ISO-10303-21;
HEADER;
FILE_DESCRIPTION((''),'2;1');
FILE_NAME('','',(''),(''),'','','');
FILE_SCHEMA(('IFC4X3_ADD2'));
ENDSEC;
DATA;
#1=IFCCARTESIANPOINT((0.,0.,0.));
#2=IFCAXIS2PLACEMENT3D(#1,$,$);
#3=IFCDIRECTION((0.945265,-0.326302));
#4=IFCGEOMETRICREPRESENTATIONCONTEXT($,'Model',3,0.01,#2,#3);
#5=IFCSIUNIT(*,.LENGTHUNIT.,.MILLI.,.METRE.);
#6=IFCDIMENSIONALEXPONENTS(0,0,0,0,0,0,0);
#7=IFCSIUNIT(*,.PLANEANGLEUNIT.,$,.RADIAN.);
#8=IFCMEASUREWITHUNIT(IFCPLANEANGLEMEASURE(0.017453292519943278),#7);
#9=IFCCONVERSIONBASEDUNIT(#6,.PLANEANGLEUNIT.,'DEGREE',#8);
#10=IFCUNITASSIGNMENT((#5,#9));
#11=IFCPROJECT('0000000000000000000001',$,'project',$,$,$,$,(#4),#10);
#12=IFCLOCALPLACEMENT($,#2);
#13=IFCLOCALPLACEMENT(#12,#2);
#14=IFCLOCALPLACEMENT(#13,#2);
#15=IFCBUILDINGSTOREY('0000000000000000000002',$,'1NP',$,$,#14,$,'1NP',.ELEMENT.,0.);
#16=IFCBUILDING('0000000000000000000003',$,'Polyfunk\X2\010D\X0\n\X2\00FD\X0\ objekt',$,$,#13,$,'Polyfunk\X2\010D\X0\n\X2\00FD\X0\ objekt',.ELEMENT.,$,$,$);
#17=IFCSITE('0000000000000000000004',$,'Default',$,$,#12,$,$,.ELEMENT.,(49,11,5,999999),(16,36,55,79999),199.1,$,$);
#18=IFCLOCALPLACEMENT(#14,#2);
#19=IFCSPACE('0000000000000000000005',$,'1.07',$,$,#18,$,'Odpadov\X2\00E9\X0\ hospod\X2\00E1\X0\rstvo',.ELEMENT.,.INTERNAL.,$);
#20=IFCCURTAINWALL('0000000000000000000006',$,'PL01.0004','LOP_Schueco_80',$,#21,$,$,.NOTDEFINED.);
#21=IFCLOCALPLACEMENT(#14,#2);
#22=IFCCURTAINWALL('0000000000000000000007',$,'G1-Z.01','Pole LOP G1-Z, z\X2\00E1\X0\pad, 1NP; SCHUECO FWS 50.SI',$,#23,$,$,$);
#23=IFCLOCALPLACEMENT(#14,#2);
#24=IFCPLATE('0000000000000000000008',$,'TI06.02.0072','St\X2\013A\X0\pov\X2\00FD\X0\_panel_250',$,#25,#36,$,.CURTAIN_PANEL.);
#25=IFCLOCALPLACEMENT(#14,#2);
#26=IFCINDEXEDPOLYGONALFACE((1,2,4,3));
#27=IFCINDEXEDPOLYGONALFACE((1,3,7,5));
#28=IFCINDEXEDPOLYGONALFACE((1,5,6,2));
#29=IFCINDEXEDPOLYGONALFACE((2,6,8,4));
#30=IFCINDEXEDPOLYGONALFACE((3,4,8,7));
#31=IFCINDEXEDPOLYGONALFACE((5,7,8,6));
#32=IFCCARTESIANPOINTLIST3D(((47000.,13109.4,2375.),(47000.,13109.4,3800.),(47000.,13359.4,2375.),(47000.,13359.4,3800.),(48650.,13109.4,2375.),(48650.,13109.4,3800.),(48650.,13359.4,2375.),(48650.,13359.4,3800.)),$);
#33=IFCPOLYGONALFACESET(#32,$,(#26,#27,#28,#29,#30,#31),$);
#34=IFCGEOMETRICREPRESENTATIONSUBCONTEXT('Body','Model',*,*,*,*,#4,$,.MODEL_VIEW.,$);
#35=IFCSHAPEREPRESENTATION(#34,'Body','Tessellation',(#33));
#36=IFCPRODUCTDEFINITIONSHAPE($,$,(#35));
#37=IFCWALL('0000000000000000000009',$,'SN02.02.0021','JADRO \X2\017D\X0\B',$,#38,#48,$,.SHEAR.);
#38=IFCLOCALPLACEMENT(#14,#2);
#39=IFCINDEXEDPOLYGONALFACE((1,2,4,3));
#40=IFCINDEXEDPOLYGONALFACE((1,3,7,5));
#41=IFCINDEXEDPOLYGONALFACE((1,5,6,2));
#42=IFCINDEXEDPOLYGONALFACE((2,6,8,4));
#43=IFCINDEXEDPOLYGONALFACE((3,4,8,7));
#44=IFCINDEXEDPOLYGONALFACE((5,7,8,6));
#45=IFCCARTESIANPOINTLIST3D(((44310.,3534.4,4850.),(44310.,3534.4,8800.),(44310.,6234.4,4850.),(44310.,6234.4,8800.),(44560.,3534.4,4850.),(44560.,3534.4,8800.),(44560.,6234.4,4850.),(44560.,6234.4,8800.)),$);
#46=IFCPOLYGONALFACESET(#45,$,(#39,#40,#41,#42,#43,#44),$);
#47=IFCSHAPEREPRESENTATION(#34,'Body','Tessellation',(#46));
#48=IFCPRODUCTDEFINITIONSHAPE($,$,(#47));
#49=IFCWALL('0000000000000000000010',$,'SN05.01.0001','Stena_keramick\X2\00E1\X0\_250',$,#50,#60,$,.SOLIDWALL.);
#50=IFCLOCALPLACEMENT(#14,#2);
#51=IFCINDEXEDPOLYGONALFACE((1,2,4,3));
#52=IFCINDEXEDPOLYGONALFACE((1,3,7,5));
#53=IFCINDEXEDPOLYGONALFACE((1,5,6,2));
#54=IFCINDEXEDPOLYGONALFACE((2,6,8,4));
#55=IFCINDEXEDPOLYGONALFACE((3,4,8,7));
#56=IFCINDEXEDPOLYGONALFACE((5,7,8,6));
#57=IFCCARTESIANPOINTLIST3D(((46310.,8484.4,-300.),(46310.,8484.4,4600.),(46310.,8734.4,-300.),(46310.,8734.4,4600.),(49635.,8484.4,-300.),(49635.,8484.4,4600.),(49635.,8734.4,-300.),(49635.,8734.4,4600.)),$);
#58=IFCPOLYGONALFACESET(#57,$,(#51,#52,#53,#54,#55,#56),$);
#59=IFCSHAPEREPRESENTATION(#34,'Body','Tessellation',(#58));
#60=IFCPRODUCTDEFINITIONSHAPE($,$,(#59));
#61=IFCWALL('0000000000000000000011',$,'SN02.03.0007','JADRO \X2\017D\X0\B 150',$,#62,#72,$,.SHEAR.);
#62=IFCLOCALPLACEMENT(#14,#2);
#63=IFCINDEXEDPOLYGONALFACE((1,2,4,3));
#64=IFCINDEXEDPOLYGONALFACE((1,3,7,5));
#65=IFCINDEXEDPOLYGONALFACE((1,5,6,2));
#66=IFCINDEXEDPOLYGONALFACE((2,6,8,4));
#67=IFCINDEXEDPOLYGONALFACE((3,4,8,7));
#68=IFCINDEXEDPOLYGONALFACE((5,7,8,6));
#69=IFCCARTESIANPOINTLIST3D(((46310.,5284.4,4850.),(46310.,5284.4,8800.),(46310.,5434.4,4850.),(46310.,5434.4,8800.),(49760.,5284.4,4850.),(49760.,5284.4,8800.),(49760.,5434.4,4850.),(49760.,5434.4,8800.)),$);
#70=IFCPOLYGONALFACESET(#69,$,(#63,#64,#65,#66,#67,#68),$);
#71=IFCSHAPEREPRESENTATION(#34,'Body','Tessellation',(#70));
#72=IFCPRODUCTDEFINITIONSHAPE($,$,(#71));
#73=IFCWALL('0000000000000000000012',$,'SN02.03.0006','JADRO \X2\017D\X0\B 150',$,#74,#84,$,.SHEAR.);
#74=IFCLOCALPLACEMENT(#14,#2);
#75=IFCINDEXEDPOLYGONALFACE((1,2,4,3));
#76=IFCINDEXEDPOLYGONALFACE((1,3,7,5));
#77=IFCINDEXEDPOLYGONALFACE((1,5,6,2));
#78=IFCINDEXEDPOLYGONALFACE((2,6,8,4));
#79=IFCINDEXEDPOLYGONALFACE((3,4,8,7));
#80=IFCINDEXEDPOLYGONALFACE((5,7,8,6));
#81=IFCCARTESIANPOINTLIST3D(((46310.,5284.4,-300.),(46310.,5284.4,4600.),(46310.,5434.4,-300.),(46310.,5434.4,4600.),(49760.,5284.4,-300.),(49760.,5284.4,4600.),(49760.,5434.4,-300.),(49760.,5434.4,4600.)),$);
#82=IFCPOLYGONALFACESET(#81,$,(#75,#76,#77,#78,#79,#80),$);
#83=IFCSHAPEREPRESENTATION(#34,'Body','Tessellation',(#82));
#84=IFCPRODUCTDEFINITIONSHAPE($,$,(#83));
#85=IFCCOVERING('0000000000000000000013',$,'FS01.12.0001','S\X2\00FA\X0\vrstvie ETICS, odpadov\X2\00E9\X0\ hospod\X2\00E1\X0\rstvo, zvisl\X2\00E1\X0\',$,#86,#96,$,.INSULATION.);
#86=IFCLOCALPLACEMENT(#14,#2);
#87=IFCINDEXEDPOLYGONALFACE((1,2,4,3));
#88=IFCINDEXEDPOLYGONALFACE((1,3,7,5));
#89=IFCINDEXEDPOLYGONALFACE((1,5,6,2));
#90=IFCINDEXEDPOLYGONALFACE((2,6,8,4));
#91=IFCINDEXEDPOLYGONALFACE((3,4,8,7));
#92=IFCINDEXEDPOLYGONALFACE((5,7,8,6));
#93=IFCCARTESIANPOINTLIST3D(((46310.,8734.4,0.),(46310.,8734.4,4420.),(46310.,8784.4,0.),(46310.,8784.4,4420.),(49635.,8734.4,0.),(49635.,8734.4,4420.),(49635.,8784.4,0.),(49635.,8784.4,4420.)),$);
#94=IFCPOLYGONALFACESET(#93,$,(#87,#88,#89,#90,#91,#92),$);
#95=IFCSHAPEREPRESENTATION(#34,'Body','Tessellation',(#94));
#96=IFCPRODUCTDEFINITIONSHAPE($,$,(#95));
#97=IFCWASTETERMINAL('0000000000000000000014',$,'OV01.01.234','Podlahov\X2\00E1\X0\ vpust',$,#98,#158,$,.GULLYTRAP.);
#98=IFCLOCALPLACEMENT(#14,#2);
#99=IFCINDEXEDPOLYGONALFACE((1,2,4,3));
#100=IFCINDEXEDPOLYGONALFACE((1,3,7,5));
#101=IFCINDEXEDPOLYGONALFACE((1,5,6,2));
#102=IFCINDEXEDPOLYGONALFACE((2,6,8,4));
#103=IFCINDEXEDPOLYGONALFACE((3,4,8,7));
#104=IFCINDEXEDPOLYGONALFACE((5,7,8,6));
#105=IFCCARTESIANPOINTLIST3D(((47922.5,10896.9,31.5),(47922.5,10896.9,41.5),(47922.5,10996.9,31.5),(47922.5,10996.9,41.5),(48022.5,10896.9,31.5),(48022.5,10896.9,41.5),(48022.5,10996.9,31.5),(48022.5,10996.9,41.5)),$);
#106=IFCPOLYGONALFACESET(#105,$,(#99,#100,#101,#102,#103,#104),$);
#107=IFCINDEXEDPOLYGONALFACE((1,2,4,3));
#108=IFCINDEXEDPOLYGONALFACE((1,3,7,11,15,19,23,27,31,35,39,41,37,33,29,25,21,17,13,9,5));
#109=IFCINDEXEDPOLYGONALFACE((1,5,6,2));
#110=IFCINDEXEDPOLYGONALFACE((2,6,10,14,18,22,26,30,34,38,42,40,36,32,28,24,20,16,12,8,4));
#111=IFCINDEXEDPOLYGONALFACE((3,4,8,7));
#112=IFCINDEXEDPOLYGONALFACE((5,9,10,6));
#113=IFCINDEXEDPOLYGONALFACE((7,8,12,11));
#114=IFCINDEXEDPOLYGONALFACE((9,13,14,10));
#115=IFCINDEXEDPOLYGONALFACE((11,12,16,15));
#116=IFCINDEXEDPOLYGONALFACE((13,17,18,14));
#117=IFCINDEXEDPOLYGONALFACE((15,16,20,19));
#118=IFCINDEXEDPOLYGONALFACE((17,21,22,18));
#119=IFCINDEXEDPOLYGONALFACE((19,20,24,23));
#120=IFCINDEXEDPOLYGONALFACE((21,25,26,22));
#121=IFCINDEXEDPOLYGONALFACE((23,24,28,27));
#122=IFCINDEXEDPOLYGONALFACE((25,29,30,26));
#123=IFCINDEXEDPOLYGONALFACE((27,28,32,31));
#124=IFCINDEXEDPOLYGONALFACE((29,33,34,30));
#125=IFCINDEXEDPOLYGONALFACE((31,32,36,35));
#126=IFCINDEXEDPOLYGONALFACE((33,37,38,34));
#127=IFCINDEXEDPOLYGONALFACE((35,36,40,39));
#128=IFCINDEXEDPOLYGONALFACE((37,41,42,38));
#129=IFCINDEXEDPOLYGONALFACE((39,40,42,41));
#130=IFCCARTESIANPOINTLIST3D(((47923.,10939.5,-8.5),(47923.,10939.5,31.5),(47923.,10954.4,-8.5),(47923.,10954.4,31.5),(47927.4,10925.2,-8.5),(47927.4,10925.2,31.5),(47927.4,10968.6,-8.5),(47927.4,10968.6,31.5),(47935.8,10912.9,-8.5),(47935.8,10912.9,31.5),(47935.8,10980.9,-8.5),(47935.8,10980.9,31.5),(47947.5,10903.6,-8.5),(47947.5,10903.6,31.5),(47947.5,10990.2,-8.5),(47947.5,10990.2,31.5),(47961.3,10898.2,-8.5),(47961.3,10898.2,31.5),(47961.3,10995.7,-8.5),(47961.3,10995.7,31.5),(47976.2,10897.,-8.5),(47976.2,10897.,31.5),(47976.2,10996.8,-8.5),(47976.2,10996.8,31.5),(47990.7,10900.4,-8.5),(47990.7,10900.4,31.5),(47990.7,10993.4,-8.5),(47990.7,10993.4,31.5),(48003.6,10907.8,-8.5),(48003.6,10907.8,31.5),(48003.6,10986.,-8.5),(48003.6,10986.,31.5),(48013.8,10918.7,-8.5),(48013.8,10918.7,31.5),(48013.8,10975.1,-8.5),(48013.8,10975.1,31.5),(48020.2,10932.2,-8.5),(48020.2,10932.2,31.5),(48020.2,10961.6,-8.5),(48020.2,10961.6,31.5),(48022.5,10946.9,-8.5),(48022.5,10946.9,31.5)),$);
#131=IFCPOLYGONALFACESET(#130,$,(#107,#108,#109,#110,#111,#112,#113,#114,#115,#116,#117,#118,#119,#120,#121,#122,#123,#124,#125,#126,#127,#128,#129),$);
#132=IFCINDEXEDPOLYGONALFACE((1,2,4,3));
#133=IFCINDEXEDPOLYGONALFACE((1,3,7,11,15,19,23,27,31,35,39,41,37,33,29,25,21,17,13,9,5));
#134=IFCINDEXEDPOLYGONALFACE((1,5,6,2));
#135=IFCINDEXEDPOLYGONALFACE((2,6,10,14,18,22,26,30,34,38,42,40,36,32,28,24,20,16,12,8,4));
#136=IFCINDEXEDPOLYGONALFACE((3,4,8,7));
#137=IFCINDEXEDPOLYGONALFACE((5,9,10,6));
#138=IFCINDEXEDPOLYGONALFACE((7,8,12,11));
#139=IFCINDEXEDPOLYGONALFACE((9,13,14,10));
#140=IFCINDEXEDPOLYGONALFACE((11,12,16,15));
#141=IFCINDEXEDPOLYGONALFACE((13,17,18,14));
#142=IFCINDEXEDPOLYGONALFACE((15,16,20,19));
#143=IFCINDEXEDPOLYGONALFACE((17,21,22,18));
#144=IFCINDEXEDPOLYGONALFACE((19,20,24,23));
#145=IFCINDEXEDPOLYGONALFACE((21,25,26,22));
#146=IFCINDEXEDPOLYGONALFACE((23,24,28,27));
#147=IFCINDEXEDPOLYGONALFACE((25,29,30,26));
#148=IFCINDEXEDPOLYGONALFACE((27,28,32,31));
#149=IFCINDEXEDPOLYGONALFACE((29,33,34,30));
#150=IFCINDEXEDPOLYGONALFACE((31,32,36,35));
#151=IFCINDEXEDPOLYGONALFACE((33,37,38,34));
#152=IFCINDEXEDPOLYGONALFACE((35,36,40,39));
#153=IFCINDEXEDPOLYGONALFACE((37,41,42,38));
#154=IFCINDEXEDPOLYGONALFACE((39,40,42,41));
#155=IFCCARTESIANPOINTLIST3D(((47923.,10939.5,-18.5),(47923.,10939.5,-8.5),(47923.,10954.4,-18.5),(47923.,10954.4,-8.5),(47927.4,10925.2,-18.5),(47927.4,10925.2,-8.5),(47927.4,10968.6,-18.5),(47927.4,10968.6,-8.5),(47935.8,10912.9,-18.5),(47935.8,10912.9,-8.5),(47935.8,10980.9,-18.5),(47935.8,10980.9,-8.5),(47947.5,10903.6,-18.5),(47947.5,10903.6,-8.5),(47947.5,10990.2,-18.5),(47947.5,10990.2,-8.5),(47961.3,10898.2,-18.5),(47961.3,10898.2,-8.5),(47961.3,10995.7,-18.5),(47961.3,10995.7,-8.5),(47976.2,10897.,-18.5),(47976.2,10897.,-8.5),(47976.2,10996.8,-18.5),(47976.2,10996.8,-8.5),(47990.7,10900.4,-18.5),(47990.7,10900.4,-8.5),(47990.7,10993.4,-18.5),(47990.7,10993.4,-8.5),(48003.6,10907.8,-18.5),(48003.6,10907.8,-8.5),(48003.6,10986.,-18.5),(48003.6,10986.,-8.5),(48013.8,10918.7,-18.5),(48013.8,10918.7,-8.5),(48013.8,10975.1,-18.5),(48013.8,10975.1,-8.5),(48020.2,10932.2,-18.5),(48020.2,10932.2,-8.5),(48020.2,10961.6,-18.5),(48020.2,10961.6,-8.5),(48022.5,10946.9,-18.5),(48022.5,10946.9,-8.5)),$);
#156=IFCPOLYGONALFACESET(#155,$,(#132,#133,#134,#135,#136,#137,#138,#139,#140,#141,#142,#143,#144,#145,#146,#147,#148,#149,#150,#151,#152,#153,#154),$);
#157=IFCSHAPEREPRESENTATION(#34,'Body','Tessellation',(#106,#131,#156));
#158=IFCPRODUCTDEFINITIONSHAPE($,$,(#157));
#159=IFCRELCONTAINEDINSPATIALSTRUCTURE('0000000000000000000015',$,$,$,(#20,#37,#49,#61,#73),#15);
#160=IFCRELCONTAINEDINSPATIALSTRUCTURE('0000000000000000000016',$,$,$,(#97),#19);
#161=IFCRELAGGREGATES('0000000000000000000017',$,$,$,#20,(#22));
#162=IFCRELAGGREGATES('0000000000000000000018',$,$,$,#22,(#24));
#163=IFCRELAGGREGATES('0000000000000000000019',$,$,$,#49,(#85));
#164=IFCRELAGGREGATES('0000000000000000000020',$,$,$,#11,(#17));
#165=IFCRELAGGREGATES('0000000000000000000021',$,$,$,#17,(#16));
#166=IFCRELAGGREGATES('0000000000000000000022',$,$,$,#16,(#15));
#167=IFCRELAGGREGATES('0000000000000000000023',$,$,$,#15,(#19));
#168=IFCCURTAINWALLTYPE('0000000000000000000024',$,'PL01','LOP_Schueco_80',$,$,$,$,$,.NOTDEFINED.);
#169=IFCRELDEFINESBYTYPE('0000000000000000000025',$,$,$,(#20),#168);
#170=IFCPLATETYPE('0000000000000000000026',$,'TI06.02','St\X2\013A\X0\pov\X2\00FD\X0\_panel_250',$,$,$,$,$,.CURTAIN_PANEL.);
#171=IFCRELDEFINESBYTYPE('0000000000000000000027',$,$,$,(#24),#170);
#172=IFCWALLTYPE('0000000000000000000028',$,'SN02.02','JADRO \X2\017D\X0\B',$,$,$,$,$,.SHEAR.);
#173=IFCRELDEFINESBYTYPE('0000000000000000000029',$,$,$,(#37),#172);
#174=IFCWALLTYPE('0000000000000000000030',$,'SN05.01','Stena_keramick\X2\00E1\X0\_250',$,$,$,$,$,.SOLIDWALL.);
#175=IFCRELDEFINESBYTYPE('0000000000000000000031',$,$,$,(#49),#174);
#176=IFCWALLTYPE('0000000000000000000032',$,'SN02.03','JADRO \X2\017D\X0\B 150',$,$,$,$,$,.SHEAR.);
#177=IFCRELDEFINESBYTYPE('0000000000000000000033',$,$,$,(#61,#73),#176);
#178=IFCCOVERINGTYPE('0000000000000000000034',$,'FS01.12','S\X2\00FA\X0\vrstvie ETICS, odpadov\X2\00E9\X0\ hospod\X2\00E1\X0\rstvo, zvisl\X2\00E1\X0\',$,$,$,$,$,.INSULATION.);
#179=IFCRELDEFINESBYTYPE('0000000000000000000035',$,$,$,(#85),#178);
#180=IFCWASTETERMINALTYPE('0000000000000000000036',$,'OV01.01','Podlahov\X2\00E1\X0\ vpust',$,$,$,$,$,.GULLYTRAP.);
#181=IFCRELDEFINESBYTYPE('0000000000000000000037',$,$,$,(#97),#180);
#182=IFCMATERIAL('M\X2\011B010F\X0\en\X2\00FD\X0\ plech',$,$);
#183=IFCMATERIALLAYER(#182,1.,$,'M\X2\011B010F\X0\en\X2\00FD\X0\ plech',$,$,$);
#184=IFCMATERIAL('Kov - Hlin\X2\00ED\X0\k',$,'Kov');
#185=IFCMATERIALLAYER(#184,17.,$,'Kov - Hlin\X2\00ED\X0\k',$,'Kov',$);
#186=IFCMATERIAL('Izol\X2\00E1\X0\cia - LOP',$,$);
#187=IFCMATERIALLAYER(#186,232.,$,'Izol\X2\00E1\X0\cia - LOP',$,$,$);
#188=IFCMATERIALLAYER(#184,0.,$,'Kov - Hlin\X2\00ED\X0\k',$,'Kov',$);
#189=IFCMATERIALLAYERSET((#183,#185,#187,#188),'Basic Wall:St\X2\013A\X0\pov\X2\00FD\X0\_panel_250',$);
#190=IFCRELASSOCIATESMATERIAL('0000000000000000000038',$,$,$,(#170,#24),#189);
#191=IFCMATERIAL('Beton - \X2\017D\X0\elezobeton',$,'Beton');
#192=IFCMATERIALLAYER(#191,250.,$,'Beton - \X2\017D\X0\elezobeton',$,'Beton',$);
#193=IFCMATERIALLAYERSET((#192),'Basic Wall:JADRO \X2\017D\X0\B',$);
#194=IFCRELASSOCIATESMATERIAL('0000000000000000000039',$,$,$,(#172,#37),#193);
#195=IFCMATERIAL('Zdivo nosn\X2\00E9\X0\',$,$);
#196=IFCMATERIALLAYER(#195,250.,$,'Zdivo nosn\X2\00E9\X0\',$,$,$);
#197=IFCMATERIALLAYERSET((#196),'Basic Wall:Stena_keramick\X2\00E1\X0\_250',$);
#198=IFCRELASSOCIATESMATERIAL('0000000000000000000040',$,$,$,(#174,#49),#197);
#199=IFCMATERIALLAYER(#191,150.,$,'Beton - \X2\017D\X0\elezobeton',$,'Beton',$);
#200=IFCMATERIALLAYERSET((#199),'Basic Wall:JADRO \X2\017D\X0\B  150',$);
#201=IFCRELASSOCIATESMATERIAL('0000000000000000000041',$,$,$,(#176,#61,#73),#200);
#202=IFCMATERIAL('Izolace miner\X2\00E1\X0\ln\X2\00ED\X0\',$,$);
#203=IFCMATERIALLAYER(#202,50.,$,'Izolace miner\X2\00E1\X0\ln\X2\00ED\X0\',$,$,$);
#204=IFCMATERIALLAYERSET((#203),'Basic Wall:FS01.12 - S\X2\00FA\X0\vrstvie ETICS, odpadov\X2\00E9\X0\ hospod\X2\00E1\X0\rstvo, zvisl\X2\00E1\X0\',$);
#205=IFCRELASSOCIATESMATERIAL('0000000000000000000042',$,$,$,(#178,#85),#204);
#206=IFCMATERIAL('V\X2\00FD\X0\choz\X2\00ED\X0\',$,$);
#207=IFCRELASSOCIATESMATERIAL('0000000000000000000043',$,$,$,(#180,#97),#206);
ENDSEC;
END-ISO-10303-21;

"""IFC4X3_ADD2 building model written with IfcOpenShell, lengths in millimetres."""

from ifc_helpers import new_model, entity, si_unit, converted_unit, direction, frame, frame_2d, origin, place, context, subcontext, project, spatial, polyline, rectangle, circle, extrude, clip, bounded_halfspace, source, transform, mapped, material, layer, layer_set, layer_usage, type_object, type_shapes, element, aggregate, save


model = new_model("IFC4X3_ADD2")

# Units and contexts
model_context = context("Model", 3, precision=0.01, world=origin(), true_north=direction((0.945265, -0.326302)))
body_context = subcontext(model_context, "Body", "Model", "MODEL_VIEW")
ifc_project = project(units=[si_unit("LENGTHUNIT", "METRE", prefix="MILLI"), converted_unit("PLANEANGLEUNIT", "DEGREE", entity("IfcPlaneAngleMeasure", 0.017453292519943278), si_unit("PLANEANGLEUNIT", "RADIAN"), dimensions=[0, 0, 0, 0, 0, 0, 0])], contexts=[model_context])

# Site, building, storey
site_placement = place(None, origin())
site = spatial("IfcSite", under=ifc_project, at=site_placement, Name="Default", CompositionType="ELEMENT", RefLatitude=(49, 11, 5, 999999), RefLongitude=(16, 36, 55, 79999), RefElevation=199.1)
building_placement = place(site_placement, origin())
building = spatial("IfcBuilding", under=site, at=building_placement, Name="Polyfunkčný objekt", LongName="Polyfunkčný objekt", CompositionType="ELEMENT")
storey_placement = place(building_placement, origin())
storey = spatial("IfcBuildingStorey", under=building, at=storey_placement, Name="1NP", LongName="1NP", CompositionType="ELEMENT", Elevation=0.0)

# Curtain walls, plate
curtain_wall_type = type_object("IfcCurtainWallType", Name="PL01", Description="LOP_Schueco_80", PredefinedType="NOTDEFINED")
curtain_wall_1_placement = place(storey_placement, origin())
curtain_wall_1 = element("IfcCurtainWall", 1, at=curtain_wall_1_placement, inside=storey, type_object=curtain_wall_type, Name="PL01.0004", Description="LOP_Schueco_80", PredefinedType="NOTDEFINED")
curtain_wall_2 = element("IfcCurtainWall", 2, Name="G1-Z.01", Description="Pole LOP G1-Z, západ, 1NP; SCHUECO FWS 50.SI")
aggregate(curtain_wall_1, [curtain_wall_2])
ifc_material_1 = material(Name="Měďený plech")
ifc_layer_1 = layer(ifc_material_1, 1.0, Name="Měďený plech")
ifc_material_2 = material(Name="Kov - Hliník", Category="Kov")
ifc_layer_2 = layer(ifc_material_2, 17.0, Name="Kov - Hliník", Category="Kov")
ifc_material_3 = material(Name="Izolácia - LOP")
ifc_layer_3 = layer(ifc_material_3, 232.0, Name="Izolácia - LOP")
ifc_layer_4 = layer(ifc_material_2, 0.0, Name="Kov - Hliník", Category="Kov")
ifc_layer_set_1 = layer_set([ifc_layer_1, ifc_layer_2, ifc_layer_3, ifc_layer_4], Name="Basic Wall:Stĺpový_panel_250")
ifc_layer_usage = layer_usage(ifc_layer_set_1, "AXIS2", "NEGATIVE", 125.0)
plate_type = type_object("IfcPlateType", Name="TI06.02", Description="Stĺpový_panel_250", PredefinedType="CURTAIN_PANEL", material=ifc_layer_set_1)
plate_placement = place(storey_placement, frame((47000.0, 13234.4, 2375.0)))
plate = element("IfcPlate", 3, at=plate_placement, type_object=plate_type, material=ifc_layer_usage, Name="TI06.02.0072", Description="Stĺpový_panel_250", PredefinedType="CURTAIN_PANEL", context=body_context, shape_type="SweptSolid", body=[
    extrude(rectangle(XDim=250.0, YDim=1650.0, at=frame_2d((0.0, 0.0), x_axis=(1.0, 0.0))), frame((825.0, 0.0, 0.0), z_axis=(0.0, 0.0, 1.0), x_axis=(0.0, 1.0, 0.0)), (0.0, 0.0, 1.0), 1425.0),
])
aggregate(curtain_wall_2, [plate])

# Walls
ifc_material_4 = material(Name="Beton - Železobeton", Category="Beton")
ifc_layer_5 = layer(ifc_material_4, 250.0, Name="Beton - Železobeton", Category="Beton")
ifc_layer_set_2 = layer_set([ifc_layer_5], Name="Basic Wall:JADRO ŽB")
wall_type_1 = type_object("IfcWallType", Name="SN02.02", Description="JADRO ŽB", PredefinedType="SHEAR", material=ifc_layer_set_2)
wall_1_placement = place(storey_placement, frame((44435.0, 6234.4, 4850.0), z_axis=(0.0, 0.0, 1.0), x_axis=(0.0, -1.0, 0.0)))
element("IfcWall", 4, at=wall_1_placement, inside=storey, type_object=wall_type_1, material=ifc_layer_set_2, Name="SN02.02.0021", Description="JADRO ŽB", PredefinedType="SHEAR", context=body_context, shape_type="Clipping", body=[
    clip(clip(extrude(rectangle(XDim=2700.0, YDim=250.0, at=frame_2d((1350.0, 0.0), x_axis=(-1.0, 0.0))), origin(), (0.0, 0.0, 1.0), 3950.0), bounded_halfspace(frame((2700.0, -125.0, 0.0), z_axis=(0.0, 0.0, 1.0), x_axis=(0.0, -1.0, 0.0)), True, frame((2700.0, -125.0, 0.0)), polyline([(0.0, 0.0), (0.0, 250.0), (-2700.0, 250.0), (-2700.0, 0.0), (0.0, 0.0)]))), bounded_halfspace(frame((0.0, -125.0, 3950.0), z_axis=(0.0, 0.0, -1.0), x_axis=(0.0, 1.0, 0.0)), True, frame((0.0, -125.0, 3950.0)), polyline([(0.0, 0.0), (2700.0, 0.0), (2700.0, 250.0), (0.0, 250.0), (0.0, 0.0)]))),
])
ifc_material_5 = material(Name="Zdivo nosné")
ifc_layer_6 = layer(ifc_material_5, 250.0, Name="Zdivo nosné")
ifc_layer_set_3 = layer_set([ifc_layer_6], Name="Basic Wall:Stena_keramická_250")
wall_type_2 = type_object("IfcWallType", Name="SN05.01", Description="Stena_keramická_250", PredefinedType="SOLIDWALL", material=ifc_layer_set_3)
wall_2_placement = place(storey_placement, frame((46310.0, 8609.4, -300.0)))
wall_2 = element("IfcWall", 5, at=wall_2_placement, inside=storey, type_object=wall_type_2, material=ifc_layer_set_3, Name="SN05.01.0001", Description="Stena_keramická_250", PredefinedType="SOLIDWALL", context=body_context, shape_type="Clipping", body=[
    clip(clip(extrude(rectangle(XDim=3325.0, YDim=250.0, at=frame_2d((1662.5, 0.0), x_axis=(-1.0, 0.0))), origin(), (0.0, 0.0, 1.0), 4900.0), bounded_halfspace(frame((0.0, -125.0, 4900.0), z_axis=(0.0, 0.0, -1.0), x_axis=(1.0, 0.0, 0.0)), True, frame((0.0, -125.0, 4900.0)), polyline([(0.0, 0.0), (3325.0, 0.0), (3325.0, 250.0), (0.0, 250.0), (0.0, 0.0)]))), bounded_halfspace(frame((3325.0, -125.0, 0.0), z_axis=(0.0, 0.0, 1.0), x_axis=(0.0, 1.0, 0.0)), True, frame((3325.0, -125.0, 0.0)), polyline([(0.0, 0.0), (0.0, 250.0), (-3325.0, 250.0), (-3325.0, 0.0), (0.0, 0.0)]))),
])

# Walls
ifc_layer_7 = layer(ifc_material_4, 150.0, Name="Beton - Železobeton", Category="Beton")
ifc_layer_set_4 = layer_set([ifc_layer_7], Name="Basic Wall:JADRO ŽB  150")
wall_type_3 = type_object("IfcWallType", Name="SN02.03", Description="JADRO ŽB 150", PredefinedType="SHEAR", material=ifc_layer_set_4)
wall_3_placement = place(storey_placement, frame((46310.0, 5359.4, 4850.0)))
element("IfcWall", 6, at=wall_3_placement, inside=storey, type_object=wall_type_3, material=ifc_layer_set_4, Name="SN02.03.0007", Description="JADRO ŽB 150", PredefinedType="SHEAR", context=body_context, shape_type="SweptSolid", body=[
    extrude(rectangle(XDim=3450.0, YDim=150.0, at=frame_2d((1725.0, 0.0), x_axis=(-1.0, 0.0))), origin(), (0.0, 0.0, 1.0), 3950.0),
])
wall_4_placement = place(storey_placement, frame((46310.0, 5359.4, -300.0)))
element("IfcWall", 7, at=wall_4_placement, inside=storey, type_object=wall_type_3, material=ifc_layer_set_4, Name="SN02.03.0006", Description="JADRO ŽB 150", PredefinedType="SHEAR", context=body_context, shape_type="SweptSolid", body=[
    extrude(rectangle(XDim=3450.0, YDim=150.0, at=frame_2d((1725.0, 0.0), x_axis=(-1.0, 0.0))), origin(), (0.0, 0.0, 1.0), 4900.0),
])

# Covering
ifc_material_6 = material(Name="Izolace minerální")
ifc_layer_8 = layer(ifc_material_6, 50.0, Name="Izolace minerální")
ifc_layer_set_5 = layer_set([ifc_layer_8], Name="Basic Wall:FS01.12 - Súvrstvie ETICS, odpadové hospodárstvo, zvislá")
covering_type = type_object("IfcCoveringType", Name="FS01.12", Description="Súvrstvie ETICS, odpadové hospodárstvo, zvislá", PredefinedType="INSULATION", material=ifc_layer_set_5)
covering_placement = place(storey_placement, frame((46310.0, 8759.4, 0.0)))
covering = element("IfcCovering", 8, at=covering_placement, type_object=covering_type, material=ifc_layer_set_5, Name="FS01.12.0001", Description="Súvrstvie ETICS, odpadové hospodárstvo, zvislá", PredefinedType="INSULATION", context=body_context, shape_type="SweptSolid", body=[
    extrude(rectangle(XDim=3325.0, YDim=50.0, at=frame_2d((1662.5, 0.0), x_axis=(-1.0, 0.0))), origin(), (0.0, 0.0, 1.0), 4420.0),
])
aggregate(wall_2, [covering])

# Shared definitions
space_placement = place(storey_placement, origin())
space = spatial("IfcSpace", under=storey, at=space_placement, Name="1.07", LongName="Odpadové hospodárstvo", CompositionType="ELEMENT", PredefinedType="INTERNAL")

# Waste terminal
ifc_material_7 = material(Name="Výchozí")
waste_terminal_type = type_object("IfcWasteTerminalType", Name="OV01.01", Description="Podlahová vpust", PredefinedType="GULLYTRAP", material=ifc_material_7)
shared_shape_1 = source(origin(), body_context, "Body", "SweptSolid", [
    extrude(rectangle(XDim=100.0, YDim=100.0, at=frame_2d((0.0, 0.0), x_axis=(1.0, 0.0))), frame((0.0, 0.0, -10.0), z_axis=(0.0, 0.0, 1.0), x_axis=(-1.0, 0.0, 0.0)), (0.0, 0.0, 1.0), 10.0),
    extrude(circle(Radius=50.0, at=frame_2d((0.0, 0.0), x_axis=(1.0, 0.0))), frame((0.0, 0.0, -50.0)), (0.0, 0.0, 1.0), 40.0),
    extrude(circle(Radius=50.0, at=frame_2d((0.0, 0.0), x_axis=(1.0, 0.0))), frame((0.0, 0.0, -60.0)), (0.0, 0.0, 1.0), 10.0),
])
type_shapes(waste_terminal_type, [shared_shape_1])
waste_terminal_placement = place(storey_placement, frame((47972.5, 10946.9, 41.5)))
element("IfcWasteTerminal", 9, at=waste_terminal_placement, inside=space, type_object=waste_terminal_type, material=ifc_material_7, Name="OV01.01.234", Description="Podlahová vpust", PredefinedType="GULLYTRAP", context=body_context, shape_type="MappedRepresentation", body=[
    mapped(shared_shape_1, transform((0.0, 0.0, 0.0), scale=1.0)),
])

save(model, "model.ifc")
